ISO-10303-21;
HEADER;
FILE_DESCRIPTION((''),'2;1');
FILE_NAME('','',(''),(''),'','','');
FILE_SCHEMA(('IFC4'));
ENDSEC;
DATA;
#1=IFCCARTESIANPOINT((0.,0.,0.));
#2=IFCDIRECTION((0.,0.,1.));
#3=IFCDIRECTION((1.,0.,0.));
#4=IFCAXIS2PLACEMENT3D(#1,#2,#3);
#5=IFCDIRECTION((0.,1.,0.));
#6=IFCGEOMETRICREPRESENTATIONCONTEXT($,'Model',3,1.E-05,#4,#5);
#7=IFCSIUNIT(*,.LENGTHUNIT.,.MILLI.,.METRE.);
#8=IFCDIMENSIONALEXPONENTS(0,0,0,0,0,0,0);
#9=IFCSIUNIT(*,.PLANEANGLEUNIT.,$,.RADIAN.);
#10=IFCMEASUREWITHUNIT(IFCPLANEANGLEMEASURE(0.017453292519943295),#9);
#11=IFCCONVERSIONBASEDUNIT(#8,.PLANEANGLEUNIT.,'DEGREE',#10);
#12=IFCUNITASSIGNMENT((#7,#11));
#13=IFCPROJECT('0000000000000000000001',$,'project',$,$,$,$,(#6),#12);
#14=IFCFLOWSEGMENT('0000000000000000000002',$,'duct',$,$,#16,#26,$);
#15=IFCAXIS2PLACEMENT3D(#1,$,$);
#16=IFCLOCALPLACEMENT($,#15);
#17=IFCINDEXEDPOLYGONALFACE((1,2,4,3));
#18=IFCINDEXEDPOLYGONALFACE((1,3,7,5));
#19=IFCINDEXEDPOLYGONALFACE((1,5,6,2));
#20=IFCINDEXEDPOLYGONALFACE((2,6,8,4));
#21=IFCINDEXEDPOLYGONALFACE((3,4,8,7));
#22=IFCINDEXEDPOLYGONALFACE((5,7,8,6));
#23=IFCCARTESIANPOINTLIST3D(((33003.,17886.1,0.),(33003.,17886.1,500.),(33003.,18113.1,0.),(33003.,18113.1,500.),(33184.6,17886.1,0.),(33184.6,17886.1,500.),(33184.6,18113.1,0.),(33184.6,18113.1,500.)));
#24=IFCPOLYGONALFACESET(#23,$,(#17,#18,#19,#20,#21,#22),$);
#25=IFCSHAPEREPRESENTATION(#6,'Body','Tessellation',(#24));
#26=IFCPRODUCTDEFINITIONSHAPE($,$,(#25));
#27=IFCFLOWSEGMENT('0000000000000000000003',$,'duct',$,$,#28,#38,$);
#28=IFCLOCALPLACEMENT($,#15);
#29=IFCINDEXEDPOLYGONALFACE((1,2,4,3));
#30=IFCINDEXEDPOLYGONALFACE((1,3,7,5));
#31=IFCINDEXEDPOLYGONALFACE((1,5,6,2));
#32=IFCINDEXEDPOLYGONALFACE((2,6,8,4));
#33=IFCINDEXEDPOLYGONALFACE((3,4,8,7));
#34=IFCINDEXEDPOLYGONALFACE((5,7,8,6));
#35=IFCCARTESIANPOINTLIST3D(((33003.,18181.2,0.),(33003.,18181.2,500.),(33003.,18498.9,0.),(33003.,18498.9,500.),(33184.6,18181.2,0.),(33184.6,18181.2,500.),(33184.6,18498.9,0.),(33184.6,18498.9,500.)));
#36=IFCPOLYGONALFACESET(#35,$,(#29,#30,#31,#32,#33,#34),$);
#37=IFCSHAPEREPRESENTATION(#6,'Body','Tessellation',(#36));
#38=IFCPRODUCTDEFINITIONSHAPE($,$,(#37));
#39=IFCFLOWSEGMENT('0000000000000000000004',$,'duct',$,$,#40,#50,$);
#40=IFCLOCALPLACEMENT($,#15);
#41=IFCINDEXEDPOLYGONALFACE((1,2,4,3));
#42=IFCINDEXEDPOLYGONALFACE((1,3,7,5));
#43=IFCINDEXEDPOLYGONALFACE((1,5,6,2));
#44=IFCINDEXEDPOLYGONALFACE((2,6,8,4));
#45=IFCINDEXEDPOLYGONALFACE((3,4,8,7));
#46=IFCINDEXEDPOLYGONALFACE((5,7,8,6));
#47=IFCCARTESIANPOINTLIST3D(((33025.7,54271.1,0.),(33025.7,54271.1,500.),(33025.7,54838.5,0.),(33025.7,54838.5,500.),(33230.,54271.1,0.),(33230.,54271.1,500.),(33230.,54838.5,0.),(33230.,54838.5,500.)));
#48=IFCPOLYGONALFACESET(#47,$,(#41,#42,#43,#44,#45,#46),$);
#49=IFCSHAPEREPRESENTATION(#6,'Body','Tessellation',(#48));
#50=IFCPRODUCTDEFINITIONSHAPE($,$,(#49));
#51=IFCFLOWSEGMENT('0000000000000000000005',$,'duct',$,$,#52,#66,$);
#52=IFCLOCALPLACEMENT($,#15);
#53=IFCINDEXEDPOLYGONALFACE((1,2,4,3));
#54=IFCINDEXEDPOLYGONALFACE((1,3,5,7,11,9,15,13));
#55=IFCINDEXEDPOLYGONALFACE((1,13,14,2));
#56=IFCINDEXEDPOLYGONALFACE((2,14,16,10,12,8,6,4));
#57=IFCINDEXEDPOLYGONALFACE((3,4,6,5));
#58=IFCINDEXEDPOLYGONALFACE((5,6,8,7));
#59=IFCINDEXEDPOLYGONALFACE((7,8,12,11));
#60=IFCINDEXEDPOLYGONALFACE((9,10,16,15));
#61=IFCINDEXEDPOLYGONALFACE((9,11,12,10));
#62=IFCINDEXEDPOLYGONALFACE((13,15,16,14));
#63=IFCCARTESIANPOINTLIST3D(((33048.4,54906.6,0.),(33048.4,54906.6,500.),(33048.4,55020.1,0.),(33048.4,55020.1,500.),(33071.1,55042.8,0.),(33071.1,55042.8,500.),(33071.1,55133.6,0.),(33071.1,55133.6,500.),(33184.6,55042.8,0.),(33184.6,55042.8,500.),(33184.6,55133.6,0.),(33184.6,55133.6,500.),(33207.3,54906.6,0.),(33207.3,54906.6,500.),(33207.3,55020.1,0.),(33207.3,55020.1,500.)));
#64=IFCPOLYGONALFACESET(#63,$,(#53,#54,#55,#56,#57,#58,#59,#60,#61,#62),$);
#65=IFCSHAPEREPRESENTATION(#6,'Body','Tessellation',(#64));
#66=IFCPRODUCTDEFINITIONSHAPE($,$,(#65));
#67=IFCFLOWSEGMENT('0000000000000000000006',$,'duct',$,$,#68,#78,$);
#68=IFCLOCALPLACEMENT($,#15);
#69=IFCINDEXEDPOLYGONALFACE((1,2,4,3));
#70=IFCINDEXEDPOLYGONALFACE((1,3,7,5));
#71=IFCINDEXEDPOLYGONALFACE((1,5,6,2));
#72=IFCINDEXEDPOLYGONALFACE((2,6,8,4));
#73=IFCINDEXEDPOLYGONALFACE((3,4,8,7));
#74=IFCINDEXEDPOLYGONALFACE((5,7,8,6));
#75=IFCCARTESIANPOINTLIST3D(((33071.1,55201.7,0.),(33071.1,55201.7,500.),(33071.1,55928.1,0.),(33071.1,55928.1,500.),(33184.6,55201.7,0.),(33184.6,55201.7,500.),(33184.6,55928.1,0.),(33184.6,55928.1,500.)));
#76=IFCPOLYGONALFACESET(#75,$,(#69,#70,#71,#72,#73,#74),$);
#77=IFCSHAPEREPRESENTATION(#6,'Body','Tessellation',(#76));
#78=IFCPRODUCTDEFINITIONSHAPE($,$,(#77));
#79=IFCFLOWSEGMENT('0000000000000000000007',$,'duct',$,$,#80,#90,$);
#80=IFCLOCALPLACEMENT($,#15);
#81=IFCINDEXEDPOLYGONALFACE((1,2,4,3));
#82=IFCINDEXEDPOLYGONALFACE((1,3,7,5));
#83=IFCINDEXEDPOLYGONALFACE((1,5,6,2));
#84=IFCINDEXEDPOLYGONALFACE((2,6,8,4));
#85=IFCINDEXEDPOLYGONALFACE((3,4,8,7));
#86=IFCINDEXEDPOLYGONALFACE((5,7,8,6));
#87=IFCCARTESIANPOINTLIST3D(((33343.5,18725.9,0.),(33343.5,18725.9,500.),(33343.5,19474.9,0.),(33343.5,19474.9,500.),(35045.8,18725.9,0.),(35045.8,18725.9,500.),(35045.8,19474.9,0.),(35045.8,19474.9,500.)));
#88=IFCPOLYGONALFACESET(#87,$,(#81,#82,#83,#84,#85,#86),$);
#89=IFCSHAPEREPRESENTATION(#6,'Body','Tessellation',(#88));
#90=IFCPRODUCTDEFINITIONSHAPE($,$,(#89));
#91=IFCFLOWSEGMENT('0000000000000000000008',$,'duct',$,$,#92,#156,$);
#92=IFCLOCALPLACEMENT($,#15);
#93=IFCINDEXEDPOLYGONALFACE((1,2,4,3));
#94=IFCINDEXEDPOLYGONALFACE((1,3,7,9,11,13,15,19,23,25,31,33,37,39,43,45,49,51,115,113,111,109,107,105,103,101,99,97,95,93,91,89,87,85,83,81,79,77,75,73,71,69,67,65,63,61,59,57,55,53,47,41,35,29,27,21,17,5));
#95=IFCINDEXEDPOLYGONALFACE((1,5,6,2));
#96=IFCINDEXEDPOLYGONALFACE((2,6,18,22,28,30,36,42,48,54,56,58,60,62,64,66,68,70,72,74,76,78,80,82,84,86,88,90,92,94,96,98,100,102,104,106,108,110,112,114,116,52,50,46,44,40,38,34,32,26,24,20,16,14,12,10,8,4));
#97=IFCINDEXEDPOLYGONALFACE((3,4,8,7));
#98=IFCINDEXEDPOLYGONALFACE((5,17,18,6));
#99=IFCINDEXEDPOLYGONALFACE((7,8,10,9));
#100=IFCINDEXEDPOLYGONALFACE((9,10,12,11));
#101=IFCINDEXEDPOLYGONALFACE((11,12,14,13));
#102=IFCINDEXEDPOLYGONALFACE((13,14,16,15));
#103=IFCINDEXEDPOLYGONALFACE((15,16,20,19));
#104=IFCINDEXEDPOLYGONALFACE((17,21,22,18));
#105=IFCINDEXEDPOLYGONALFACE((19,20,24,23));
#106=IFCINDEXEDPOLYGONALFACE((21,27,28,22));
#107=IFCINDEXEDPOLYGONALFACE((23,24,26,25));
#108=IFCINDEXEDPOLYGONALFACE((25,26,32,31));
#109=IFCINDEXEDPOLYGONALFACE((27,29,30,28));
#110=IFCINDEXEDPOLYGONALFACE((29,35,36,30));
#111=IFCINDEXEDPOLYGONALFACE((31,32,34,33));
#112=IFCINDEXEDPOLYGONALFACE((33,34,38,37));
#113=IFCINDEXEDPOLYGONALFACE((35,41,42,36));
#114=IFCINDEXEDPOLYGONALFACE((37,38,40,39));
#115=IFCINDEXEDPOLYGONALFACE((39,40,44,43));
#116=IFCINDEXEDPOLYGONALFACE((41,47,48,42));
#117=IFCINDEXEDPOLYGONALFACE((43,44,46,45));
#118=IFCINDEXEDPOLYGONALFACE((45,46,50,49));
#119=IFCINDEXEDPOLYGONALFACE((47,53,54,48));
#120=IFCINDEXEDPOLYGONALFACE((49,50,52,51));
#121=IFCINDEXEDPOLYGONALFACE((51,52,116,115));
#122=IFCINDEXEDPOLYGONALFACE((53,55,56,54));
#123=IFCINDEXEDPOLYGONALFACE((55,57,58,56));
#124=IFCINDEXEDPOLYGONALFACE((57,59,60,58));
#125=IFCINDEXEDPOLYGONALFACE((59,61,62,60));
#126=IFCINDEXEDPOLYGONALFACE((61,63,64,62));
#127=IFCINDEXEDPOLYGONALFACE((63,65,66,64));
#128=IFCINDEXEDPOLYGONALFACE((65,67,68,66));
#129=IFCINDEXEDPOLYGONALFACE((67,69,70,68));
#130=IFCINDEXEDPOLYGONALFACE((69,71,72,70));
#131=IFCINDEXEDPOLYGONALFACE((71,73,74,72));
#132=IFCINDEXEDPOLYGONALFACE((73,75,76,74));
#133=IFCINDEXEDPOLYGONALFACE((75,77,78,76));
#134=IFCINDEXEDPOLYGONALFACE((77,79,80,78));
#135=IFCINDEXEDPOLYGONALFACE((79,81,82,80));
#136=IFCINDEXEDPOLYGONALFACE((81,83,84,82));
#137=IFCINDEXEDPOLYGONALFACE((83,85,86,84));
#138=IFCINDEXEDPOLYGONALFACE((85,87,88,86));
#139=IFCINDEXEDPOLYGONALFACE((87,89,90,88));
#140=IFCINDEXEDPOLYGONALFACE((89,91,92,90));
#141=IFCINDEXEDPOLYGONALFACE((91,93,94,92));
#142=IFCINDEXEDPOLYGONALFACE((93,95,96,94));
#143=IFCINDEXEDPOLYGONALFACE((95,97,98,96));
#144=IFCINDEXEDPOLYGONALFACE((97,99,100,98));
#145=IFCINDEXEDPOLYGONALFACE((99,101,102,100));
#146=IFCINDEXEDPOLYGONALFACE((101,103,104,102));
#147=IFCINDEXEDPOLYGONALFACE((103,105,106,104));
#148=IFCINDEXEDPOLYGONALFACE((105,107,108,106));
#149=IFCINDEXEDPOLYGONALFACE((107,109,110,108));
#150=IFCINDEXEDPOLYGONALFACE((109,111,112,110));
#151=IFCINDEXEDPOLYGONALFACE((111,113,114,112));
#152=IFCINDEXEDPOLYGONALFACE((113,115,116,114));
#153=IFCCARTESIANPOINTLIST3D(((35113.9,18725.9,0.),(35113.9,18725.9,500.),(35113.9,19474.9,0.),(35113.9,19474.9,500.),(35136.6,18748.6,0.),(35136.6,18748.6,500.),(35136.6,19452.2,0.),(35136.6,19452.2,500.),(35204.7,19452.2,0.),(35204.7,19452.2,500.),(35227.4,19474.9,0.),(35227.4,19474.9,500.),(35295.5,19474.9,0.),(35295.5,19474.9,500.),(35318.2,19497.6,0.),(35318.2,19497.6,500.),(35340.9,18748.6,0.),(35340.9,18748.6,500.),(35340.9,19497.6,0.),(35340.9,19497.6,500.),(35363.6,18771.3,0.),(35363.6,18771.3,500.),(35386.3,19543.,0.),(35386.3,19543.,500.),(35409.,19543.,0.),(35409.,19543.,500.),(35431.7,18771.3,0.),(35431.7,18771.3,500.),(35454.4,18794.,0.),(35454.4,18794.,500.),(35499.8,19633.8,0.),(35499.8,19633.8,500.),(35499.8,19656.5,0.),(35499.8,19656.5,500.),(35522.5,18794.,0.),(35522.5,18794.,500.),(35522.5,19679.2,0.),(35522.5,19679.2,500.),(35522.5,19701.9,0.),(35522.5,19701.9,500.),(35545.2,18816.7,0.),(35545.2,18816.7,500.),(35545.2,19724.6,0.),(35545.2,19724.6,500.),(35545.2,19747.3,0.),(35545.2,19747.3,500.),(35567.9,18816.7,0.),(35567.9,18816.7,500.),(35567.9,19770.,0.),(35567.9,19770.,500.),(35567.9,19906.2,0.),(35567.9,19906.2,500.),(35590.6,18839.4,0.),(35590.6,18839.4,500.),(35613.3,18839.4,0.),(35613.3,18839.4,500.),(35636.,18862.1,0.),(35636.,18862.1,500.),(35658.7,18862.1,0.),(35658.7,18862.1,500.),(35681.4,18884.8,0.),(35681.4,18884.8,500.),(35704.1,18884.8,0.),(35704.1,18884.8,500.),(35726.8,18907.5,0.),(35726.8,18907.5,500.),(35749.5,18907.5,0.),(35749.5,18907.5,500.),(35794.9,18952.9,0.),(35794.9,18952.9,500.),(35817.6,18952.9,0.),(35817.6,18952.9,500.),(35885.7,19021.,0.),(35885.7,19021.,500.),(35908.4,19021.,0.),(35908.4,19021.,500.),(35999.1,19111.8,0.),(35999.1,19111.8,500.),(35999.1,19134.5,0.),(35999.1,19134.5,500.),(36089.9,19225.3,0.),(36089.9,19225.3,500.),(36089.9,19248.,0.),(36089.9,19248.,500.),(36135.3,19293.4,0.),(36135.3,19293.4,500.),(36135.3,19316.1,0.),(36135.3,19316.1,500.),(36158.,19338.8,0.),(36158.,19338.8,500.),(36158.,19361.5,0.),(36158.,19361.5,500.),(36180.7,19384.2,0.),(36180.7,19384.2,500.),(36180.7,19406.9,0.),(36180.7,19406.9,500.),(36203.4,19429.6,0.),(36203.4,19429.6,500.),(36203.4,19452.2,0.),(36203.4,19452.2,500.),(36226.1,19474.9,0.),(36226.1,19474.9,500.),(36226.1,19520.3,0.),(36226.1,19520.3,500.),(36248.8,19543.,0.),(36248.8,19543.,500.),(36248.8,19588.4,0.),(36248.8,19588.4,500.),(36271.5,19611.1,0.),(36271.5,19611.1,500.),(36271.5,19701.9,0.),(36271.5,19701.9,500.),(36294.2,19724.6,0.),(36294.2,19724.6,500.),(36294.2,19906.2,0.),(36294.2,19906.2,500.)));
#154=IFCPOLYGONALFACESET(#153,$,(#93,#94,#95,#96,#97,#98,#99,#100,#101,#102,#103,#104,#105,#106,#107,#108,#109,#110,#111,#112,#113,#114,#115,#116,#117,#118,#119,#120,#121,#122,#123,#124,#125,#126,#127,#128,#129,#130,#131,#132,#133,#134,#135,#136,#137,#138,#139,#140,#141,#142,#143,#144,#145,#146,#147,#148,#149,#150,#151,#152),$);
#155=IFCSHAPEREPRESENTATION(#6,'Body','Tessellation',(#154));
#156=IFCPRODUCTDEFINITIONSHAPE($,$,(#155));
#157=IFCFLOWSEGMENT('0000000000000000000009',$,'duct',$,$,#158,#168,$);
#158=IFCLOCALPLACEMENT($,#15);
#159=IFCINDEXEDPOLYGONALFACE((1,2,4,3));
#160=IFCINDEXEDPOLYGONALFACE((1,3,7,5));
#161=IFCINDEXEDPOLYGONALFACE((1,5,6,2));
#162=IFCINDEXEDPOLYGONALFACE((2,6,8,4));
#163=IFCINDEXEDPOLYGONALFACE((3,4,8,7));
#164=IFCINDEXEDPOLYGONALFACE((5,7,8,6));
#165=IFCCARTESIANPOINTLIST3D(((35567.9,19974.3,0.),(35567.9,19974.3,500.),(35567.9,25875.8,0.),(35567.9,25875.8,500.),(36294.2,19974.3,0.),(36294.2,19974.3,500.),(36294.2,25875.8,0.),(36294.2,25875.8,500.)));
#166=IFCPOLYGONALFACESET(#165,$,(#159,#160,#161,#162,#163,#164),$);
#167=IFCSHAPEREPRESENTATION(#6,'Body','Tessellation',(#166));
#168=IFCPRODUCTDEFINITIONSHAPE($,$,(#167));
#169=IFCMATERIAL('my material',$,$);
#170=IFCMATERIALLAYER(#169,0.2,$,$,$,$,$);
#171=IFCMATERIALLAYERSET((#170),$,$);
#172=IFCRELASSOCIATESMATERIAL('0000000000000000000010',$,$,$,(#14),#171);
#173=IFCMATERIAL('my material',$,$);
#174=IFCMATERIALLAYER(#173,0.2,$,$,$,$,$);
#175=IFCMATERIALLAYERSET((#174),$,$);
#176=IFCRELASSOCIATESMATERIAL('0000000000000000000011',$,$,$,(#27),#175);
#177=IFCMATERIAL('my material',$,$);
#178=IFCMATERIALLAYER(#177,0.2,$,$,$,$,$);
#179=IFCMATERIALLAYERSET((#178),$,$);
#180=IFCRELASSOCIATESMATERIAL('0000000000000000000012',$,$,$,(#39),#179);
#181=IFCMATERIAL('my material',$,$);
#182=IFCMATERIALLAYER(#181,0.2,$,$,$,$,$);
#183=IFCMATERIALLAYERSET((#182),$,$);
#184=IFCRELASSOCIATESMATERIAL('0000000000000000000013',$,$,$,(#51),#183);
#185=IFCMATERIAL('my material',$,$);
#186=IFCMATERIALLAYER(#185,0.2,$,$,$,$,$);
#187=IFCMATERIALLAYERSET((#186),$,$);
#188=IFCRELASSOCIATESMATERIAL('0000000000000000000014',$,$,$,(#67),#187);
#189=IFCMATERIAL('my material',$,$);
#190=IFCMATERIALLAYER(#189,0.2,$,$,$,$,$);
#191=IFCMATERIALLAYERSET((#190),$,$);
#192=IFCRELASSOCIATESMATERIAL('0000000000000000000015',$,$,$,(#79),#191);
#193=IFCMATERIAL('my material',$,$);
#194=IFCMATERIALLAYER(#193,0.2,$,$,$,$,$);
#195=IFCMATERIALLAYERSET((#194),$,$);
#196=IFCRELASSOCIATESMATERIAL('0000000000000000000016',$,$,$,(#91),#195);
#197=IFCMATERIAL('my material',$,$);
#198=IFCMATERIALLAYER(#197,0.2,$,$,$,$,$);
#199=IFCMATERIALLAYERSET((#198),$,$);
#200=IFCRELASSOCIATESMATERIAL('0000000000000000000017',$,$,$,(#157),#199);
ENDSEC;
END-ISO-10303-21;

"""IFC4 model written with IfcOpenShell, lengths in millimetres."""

from ifc_helpers import new_model, entity, si_unit, converted_unit, direction, origin_with_axes, place, context, project, polyline, outline, extrude, material, layer, layer_set, layer_usage, element, save


model = new_model("IFC4")

# Units and contexts
model_context = context("Model", 3, precision=1e-05, world=origin_with_axes(), true_north=direction((0.0, 1.0, 0.0)))
ifc_project = project(units=[si_unit("LENGTHUNIT", "METRE", prefix="MILLI"), converted_unit("PLANEANGLEUNIT", "DEGREE", entity("IfcPlaneAngleMeasure", 0.017453292519943295), si_unit("PLANEANGLEUNIT", "RADIAN"), dimensions=[0, 0, 0, 0, 0, 0, 0])], contexts=[model_context])

# Flow segments
ifc_material_1 = material(Name="my material")
ifc_layer_1 = layer(ifc_material_1, 0.2)
ifc_layer_set_1 = layer_set([ifc_layer_1])
ifc_layer_usage_1 = layer_usage(ifc_layer_set_1, "AXIS2", "POSITIVE", -0.1)
flow_segment_1_placement = place(None, origin_with_axes())
element("IfcFlowSegment", 1, at=flow_segment_1_placement, material=ifc_layer_usage_1, Name="duct", context=model_context, shape_type="SweptSolid", body=[
    extrude(outline(polyline([(33003.0, 17886.1), (33184.6, 17886.1), (33184.6, 18113.1), (33003.0, 18113.1), (33003.0, 17886.1)])), origin_with_axes(), (0.0, 0.0, 1.0), 500.0),
])
ifc_material_2 = material(Name="my material")
ifc_layer_2 = layer(ifc_material_2, 0.2)
ifc_layer_set_2 = layer_set([ifc_layer_2])
ifc_layer_usage_2 = layer_usage(ifc_layer_set_2, "AXIS2", "POSITIVE", -0.1)
flow_segment_2_placement = place(None, origin_with_axes())
element("IfcFlowSegment", 2, at=flow_segment_2_placement, material=ifc_layer_usage_2, Name="duct", context=model_context, shape_type="SweptSolid", body=[
    extrude(outline(polyline([(33003.0, 18181.2), (33184.6, 18181.2), (33184.6, 18498.9), (33003.0, 18498.9), (33003.0, 18181.2)])), origin_with_axes(), (0.0, 0.0, 1.0), 500.0),
])
ifc_material_3 = material(Name="my material")
ifc_layer_3 = layer(ifc_material_3, 0.2)
ifc_layer_set_3 = layer_set([ifc_layer_3])
ifc_layer_usage_3 = layer_usage(ifc_layer_set_3, "AXIS2", "POSITIVE", -0.1)
flow_segment_3_placement = place(None, origin_with_axes())
element("IfcFlowSegment", 3, at=flow_segment_3_placement, material=ifc_layer_usage_3, Name="duct", context=model_context, shape_type="SweptSolid", body=[
    extrude(outline(polyline([(33025.7, 54271.1), (33230.0, 54271.1), (33230.0, 54838.5), (33025.7, 54838.5), (33025.7, 54271.1)])), origin_with_axes(), (0.0, 0.0, 1.0), 500.0),
])
ifc_material_4 = material(Name="my material")
ifc_layer_4 = layer(ifc_material_4, 0.2)
ifc_layer_set_4 = layer_set([ifc_layer_4])
ifc_layer_usage_4 = layer_usage(ifc_layer_set_4, "AXIS2", "POSITIVE", -0.1)
flow_segment_4_placement = place(None, origin_with_axes())
element("IfcFlowSegment", 4, at=flow_segment_4_placement, material=ifc_layer_usage_4, Name="duct", context=model_context, shape_type="SweptSolid", body=[
    extrude(outline(polyline([(33048.4, 54906.6), (33207.3, 54906.6), (33207.3, 55020.1), (33184.6, 55042.8), (33184.6, 55133.6), (33071.1, 55133.6), (33071.1, 55042.8), (33048.4, 55020.1), (33048.4, 54906.6)])), origin_with_axes(), (0.0, 0.0, 1.0), 500.0),
])
ifc_material_5 = material(Name="my material")
ifc_layer_5 = layer(ifc_material_5, 0.2)
ifc_layer_set_5 = layer_set([ifc_layer_5])
ifc_layer_usage_5 = layer_usage(ifc_layer_set_5, "AXIS2", "POSITIVE", -0.1)
flow_segment_5_placement = place(None, origin_with_axes())
element("IfcFlowSegment", 5, at=flow_segment_5_placement, material=ifc_layer_usage_5, Name="duct", context=model_context, shape_type="SweptSolid", body=[
    extrude(outline(polyline([(33071.1, 55201.7), (33184.6, 55201.7), (33184.6, 55928.1), (33071.1, 55928.1), (33071.1, 55201.7)])), origin_with_axes(), (0.0, 0.0, 1.0), 500.0),
])
ifc_material_6 = material(Name="my material")
ifc_layer_6 = layer(ifc_material_6, 0.2)
ifc_layer_set_6 = layer_set([ifc_layer_6])
ifc_layer_usage_6 = layer_usage(ifc_layer_set_6, "AXIS2", "POSITIVE", -0.1)
flow_segment_6_placement = place(None, origin_with_axes())
element("IfcFlowSegment", 6, at=flow_segment_6_placement, material=ifc_layer_usage_6, Name="duct", context=model_context, shape_type="SweptSolid", body=[
    extrude(outline(polyline([(33343.5, 18725.9), (35045.8, 18725.9), (35045.8, 19474.9), (33343.5, 19474.9), (33343.5, 18725.9)])), origin_with_axes(), (0.0, 0.0, 1.0), 500.0),
])
ifc_material_7 = material(Name="my material")
ifc_layer_7 = layer(ifc_material_7, 0.2)
ifc_layer_set_7 = layer_set([ifc_layer_7])
ifc_layer_usage_7 = layer_usage(ifc_layer_set_7, "AXIS2", "POSITIVE", -0.1)
flow_segment_7_placement = place(None, origin_with_axes())
element("IfcFlowSegment", 7, at=flow_segment_7_placement, material=ifc_layer_usage_7, Name="duct", context=model_context, shape_type="SweptSolid", body=[
    extrude(outline(polyline([(35113.9, 18725.9), (35136.6, 18748.6), (35340.9, 18748.6), (35363.6, 18771.3), (35431.7, 18771.3), (35454.4, 18794.0), (35522.5, 18794.0), (35545.2, 18816.7), (35567.9, 18816.7), (35590.6, 18839.4), (35613.3, 18839.4), (35636.0, 18862.1), (35658.7, 18862.1), (35681.4, 18884.8), (35704.1, 18884.8), (35726.8, 18907.5), (35749.5, 18907.5), (35794.9, 18952.9), (35817.6, 18952.9), (35885.7, 19021.0), (35908.4, 19021.0), (35999.1, 19111.8), (35999.1, 19134.5), (36089.9, 19225.3), (36089.9, 19248.0), (36135.3, 19293.4), (36135.3, 19316.1), (36158.0, 19338.8), (36158.0, 19361.5), (36180.7, 19384.2), (36180.7, 19406.9), (36203.4, 19429.6), (36203.4, 19452.2), (36226.1, 19474.9), (36226.1, 19520.3), (36248.8, 19543.0), (36248.8, 19588.4), (36271.5, 19611.1), (36271.5, 19701.9), (36294.2, 19724.6), (36294.2, 19906.2), (35567.9, 19906.2), (35567.9, 19770.0), (35545.2, 19747.3), (35545.2, 19724.6), (35522.5, 19701.9), (35522.5, 19679.2), (35499.8, 19656.5), (35499.8, 19633.8), (35409.0, 19543.0), (35386.3, 19543.0), (35340.9, 19497.6), (35318.2, 19497.6), (35295.5, 19474.9), (35227.4, 19474.9), (35204.7, 19452.2), (35136.6, 19452.2), (35113.9, 19474.9), (35113.9, 18725.9)])), origin_with_axes(), (0.0, 0.0, 1.0), 500.0),
])
ifc_material_8 = material(Name="my material")
ifc_layer_8 = layer(ifc_material_8, 0.2)
ifc_layer_set_8 = layer_set([ifc_layer_8])
ifc_layer_usage_8 = layer_usage(ifc_layer_set_8, "AXIS2", "POSITIVE", -0.1)
flow_segment_8_placement = place(None, origin_with_axes())
element("IfcFlowSegment", 8, at=flow_segment_8_placement, material=ifc_layer_usage_8, Name="duct", context=model_context, shape_type="SweptSolid", body=[
    extrude(outline(polyline([(35567.9, 19974.3), (36294.2, 19974.3), (36294.2, 25875.8), (35567.9, 25875.8), (35567.9, 19974.3)])), origin_with_axes(), (0.0, 0.0, 1.0), 500.0),
])

save(model, "model.ifc")
